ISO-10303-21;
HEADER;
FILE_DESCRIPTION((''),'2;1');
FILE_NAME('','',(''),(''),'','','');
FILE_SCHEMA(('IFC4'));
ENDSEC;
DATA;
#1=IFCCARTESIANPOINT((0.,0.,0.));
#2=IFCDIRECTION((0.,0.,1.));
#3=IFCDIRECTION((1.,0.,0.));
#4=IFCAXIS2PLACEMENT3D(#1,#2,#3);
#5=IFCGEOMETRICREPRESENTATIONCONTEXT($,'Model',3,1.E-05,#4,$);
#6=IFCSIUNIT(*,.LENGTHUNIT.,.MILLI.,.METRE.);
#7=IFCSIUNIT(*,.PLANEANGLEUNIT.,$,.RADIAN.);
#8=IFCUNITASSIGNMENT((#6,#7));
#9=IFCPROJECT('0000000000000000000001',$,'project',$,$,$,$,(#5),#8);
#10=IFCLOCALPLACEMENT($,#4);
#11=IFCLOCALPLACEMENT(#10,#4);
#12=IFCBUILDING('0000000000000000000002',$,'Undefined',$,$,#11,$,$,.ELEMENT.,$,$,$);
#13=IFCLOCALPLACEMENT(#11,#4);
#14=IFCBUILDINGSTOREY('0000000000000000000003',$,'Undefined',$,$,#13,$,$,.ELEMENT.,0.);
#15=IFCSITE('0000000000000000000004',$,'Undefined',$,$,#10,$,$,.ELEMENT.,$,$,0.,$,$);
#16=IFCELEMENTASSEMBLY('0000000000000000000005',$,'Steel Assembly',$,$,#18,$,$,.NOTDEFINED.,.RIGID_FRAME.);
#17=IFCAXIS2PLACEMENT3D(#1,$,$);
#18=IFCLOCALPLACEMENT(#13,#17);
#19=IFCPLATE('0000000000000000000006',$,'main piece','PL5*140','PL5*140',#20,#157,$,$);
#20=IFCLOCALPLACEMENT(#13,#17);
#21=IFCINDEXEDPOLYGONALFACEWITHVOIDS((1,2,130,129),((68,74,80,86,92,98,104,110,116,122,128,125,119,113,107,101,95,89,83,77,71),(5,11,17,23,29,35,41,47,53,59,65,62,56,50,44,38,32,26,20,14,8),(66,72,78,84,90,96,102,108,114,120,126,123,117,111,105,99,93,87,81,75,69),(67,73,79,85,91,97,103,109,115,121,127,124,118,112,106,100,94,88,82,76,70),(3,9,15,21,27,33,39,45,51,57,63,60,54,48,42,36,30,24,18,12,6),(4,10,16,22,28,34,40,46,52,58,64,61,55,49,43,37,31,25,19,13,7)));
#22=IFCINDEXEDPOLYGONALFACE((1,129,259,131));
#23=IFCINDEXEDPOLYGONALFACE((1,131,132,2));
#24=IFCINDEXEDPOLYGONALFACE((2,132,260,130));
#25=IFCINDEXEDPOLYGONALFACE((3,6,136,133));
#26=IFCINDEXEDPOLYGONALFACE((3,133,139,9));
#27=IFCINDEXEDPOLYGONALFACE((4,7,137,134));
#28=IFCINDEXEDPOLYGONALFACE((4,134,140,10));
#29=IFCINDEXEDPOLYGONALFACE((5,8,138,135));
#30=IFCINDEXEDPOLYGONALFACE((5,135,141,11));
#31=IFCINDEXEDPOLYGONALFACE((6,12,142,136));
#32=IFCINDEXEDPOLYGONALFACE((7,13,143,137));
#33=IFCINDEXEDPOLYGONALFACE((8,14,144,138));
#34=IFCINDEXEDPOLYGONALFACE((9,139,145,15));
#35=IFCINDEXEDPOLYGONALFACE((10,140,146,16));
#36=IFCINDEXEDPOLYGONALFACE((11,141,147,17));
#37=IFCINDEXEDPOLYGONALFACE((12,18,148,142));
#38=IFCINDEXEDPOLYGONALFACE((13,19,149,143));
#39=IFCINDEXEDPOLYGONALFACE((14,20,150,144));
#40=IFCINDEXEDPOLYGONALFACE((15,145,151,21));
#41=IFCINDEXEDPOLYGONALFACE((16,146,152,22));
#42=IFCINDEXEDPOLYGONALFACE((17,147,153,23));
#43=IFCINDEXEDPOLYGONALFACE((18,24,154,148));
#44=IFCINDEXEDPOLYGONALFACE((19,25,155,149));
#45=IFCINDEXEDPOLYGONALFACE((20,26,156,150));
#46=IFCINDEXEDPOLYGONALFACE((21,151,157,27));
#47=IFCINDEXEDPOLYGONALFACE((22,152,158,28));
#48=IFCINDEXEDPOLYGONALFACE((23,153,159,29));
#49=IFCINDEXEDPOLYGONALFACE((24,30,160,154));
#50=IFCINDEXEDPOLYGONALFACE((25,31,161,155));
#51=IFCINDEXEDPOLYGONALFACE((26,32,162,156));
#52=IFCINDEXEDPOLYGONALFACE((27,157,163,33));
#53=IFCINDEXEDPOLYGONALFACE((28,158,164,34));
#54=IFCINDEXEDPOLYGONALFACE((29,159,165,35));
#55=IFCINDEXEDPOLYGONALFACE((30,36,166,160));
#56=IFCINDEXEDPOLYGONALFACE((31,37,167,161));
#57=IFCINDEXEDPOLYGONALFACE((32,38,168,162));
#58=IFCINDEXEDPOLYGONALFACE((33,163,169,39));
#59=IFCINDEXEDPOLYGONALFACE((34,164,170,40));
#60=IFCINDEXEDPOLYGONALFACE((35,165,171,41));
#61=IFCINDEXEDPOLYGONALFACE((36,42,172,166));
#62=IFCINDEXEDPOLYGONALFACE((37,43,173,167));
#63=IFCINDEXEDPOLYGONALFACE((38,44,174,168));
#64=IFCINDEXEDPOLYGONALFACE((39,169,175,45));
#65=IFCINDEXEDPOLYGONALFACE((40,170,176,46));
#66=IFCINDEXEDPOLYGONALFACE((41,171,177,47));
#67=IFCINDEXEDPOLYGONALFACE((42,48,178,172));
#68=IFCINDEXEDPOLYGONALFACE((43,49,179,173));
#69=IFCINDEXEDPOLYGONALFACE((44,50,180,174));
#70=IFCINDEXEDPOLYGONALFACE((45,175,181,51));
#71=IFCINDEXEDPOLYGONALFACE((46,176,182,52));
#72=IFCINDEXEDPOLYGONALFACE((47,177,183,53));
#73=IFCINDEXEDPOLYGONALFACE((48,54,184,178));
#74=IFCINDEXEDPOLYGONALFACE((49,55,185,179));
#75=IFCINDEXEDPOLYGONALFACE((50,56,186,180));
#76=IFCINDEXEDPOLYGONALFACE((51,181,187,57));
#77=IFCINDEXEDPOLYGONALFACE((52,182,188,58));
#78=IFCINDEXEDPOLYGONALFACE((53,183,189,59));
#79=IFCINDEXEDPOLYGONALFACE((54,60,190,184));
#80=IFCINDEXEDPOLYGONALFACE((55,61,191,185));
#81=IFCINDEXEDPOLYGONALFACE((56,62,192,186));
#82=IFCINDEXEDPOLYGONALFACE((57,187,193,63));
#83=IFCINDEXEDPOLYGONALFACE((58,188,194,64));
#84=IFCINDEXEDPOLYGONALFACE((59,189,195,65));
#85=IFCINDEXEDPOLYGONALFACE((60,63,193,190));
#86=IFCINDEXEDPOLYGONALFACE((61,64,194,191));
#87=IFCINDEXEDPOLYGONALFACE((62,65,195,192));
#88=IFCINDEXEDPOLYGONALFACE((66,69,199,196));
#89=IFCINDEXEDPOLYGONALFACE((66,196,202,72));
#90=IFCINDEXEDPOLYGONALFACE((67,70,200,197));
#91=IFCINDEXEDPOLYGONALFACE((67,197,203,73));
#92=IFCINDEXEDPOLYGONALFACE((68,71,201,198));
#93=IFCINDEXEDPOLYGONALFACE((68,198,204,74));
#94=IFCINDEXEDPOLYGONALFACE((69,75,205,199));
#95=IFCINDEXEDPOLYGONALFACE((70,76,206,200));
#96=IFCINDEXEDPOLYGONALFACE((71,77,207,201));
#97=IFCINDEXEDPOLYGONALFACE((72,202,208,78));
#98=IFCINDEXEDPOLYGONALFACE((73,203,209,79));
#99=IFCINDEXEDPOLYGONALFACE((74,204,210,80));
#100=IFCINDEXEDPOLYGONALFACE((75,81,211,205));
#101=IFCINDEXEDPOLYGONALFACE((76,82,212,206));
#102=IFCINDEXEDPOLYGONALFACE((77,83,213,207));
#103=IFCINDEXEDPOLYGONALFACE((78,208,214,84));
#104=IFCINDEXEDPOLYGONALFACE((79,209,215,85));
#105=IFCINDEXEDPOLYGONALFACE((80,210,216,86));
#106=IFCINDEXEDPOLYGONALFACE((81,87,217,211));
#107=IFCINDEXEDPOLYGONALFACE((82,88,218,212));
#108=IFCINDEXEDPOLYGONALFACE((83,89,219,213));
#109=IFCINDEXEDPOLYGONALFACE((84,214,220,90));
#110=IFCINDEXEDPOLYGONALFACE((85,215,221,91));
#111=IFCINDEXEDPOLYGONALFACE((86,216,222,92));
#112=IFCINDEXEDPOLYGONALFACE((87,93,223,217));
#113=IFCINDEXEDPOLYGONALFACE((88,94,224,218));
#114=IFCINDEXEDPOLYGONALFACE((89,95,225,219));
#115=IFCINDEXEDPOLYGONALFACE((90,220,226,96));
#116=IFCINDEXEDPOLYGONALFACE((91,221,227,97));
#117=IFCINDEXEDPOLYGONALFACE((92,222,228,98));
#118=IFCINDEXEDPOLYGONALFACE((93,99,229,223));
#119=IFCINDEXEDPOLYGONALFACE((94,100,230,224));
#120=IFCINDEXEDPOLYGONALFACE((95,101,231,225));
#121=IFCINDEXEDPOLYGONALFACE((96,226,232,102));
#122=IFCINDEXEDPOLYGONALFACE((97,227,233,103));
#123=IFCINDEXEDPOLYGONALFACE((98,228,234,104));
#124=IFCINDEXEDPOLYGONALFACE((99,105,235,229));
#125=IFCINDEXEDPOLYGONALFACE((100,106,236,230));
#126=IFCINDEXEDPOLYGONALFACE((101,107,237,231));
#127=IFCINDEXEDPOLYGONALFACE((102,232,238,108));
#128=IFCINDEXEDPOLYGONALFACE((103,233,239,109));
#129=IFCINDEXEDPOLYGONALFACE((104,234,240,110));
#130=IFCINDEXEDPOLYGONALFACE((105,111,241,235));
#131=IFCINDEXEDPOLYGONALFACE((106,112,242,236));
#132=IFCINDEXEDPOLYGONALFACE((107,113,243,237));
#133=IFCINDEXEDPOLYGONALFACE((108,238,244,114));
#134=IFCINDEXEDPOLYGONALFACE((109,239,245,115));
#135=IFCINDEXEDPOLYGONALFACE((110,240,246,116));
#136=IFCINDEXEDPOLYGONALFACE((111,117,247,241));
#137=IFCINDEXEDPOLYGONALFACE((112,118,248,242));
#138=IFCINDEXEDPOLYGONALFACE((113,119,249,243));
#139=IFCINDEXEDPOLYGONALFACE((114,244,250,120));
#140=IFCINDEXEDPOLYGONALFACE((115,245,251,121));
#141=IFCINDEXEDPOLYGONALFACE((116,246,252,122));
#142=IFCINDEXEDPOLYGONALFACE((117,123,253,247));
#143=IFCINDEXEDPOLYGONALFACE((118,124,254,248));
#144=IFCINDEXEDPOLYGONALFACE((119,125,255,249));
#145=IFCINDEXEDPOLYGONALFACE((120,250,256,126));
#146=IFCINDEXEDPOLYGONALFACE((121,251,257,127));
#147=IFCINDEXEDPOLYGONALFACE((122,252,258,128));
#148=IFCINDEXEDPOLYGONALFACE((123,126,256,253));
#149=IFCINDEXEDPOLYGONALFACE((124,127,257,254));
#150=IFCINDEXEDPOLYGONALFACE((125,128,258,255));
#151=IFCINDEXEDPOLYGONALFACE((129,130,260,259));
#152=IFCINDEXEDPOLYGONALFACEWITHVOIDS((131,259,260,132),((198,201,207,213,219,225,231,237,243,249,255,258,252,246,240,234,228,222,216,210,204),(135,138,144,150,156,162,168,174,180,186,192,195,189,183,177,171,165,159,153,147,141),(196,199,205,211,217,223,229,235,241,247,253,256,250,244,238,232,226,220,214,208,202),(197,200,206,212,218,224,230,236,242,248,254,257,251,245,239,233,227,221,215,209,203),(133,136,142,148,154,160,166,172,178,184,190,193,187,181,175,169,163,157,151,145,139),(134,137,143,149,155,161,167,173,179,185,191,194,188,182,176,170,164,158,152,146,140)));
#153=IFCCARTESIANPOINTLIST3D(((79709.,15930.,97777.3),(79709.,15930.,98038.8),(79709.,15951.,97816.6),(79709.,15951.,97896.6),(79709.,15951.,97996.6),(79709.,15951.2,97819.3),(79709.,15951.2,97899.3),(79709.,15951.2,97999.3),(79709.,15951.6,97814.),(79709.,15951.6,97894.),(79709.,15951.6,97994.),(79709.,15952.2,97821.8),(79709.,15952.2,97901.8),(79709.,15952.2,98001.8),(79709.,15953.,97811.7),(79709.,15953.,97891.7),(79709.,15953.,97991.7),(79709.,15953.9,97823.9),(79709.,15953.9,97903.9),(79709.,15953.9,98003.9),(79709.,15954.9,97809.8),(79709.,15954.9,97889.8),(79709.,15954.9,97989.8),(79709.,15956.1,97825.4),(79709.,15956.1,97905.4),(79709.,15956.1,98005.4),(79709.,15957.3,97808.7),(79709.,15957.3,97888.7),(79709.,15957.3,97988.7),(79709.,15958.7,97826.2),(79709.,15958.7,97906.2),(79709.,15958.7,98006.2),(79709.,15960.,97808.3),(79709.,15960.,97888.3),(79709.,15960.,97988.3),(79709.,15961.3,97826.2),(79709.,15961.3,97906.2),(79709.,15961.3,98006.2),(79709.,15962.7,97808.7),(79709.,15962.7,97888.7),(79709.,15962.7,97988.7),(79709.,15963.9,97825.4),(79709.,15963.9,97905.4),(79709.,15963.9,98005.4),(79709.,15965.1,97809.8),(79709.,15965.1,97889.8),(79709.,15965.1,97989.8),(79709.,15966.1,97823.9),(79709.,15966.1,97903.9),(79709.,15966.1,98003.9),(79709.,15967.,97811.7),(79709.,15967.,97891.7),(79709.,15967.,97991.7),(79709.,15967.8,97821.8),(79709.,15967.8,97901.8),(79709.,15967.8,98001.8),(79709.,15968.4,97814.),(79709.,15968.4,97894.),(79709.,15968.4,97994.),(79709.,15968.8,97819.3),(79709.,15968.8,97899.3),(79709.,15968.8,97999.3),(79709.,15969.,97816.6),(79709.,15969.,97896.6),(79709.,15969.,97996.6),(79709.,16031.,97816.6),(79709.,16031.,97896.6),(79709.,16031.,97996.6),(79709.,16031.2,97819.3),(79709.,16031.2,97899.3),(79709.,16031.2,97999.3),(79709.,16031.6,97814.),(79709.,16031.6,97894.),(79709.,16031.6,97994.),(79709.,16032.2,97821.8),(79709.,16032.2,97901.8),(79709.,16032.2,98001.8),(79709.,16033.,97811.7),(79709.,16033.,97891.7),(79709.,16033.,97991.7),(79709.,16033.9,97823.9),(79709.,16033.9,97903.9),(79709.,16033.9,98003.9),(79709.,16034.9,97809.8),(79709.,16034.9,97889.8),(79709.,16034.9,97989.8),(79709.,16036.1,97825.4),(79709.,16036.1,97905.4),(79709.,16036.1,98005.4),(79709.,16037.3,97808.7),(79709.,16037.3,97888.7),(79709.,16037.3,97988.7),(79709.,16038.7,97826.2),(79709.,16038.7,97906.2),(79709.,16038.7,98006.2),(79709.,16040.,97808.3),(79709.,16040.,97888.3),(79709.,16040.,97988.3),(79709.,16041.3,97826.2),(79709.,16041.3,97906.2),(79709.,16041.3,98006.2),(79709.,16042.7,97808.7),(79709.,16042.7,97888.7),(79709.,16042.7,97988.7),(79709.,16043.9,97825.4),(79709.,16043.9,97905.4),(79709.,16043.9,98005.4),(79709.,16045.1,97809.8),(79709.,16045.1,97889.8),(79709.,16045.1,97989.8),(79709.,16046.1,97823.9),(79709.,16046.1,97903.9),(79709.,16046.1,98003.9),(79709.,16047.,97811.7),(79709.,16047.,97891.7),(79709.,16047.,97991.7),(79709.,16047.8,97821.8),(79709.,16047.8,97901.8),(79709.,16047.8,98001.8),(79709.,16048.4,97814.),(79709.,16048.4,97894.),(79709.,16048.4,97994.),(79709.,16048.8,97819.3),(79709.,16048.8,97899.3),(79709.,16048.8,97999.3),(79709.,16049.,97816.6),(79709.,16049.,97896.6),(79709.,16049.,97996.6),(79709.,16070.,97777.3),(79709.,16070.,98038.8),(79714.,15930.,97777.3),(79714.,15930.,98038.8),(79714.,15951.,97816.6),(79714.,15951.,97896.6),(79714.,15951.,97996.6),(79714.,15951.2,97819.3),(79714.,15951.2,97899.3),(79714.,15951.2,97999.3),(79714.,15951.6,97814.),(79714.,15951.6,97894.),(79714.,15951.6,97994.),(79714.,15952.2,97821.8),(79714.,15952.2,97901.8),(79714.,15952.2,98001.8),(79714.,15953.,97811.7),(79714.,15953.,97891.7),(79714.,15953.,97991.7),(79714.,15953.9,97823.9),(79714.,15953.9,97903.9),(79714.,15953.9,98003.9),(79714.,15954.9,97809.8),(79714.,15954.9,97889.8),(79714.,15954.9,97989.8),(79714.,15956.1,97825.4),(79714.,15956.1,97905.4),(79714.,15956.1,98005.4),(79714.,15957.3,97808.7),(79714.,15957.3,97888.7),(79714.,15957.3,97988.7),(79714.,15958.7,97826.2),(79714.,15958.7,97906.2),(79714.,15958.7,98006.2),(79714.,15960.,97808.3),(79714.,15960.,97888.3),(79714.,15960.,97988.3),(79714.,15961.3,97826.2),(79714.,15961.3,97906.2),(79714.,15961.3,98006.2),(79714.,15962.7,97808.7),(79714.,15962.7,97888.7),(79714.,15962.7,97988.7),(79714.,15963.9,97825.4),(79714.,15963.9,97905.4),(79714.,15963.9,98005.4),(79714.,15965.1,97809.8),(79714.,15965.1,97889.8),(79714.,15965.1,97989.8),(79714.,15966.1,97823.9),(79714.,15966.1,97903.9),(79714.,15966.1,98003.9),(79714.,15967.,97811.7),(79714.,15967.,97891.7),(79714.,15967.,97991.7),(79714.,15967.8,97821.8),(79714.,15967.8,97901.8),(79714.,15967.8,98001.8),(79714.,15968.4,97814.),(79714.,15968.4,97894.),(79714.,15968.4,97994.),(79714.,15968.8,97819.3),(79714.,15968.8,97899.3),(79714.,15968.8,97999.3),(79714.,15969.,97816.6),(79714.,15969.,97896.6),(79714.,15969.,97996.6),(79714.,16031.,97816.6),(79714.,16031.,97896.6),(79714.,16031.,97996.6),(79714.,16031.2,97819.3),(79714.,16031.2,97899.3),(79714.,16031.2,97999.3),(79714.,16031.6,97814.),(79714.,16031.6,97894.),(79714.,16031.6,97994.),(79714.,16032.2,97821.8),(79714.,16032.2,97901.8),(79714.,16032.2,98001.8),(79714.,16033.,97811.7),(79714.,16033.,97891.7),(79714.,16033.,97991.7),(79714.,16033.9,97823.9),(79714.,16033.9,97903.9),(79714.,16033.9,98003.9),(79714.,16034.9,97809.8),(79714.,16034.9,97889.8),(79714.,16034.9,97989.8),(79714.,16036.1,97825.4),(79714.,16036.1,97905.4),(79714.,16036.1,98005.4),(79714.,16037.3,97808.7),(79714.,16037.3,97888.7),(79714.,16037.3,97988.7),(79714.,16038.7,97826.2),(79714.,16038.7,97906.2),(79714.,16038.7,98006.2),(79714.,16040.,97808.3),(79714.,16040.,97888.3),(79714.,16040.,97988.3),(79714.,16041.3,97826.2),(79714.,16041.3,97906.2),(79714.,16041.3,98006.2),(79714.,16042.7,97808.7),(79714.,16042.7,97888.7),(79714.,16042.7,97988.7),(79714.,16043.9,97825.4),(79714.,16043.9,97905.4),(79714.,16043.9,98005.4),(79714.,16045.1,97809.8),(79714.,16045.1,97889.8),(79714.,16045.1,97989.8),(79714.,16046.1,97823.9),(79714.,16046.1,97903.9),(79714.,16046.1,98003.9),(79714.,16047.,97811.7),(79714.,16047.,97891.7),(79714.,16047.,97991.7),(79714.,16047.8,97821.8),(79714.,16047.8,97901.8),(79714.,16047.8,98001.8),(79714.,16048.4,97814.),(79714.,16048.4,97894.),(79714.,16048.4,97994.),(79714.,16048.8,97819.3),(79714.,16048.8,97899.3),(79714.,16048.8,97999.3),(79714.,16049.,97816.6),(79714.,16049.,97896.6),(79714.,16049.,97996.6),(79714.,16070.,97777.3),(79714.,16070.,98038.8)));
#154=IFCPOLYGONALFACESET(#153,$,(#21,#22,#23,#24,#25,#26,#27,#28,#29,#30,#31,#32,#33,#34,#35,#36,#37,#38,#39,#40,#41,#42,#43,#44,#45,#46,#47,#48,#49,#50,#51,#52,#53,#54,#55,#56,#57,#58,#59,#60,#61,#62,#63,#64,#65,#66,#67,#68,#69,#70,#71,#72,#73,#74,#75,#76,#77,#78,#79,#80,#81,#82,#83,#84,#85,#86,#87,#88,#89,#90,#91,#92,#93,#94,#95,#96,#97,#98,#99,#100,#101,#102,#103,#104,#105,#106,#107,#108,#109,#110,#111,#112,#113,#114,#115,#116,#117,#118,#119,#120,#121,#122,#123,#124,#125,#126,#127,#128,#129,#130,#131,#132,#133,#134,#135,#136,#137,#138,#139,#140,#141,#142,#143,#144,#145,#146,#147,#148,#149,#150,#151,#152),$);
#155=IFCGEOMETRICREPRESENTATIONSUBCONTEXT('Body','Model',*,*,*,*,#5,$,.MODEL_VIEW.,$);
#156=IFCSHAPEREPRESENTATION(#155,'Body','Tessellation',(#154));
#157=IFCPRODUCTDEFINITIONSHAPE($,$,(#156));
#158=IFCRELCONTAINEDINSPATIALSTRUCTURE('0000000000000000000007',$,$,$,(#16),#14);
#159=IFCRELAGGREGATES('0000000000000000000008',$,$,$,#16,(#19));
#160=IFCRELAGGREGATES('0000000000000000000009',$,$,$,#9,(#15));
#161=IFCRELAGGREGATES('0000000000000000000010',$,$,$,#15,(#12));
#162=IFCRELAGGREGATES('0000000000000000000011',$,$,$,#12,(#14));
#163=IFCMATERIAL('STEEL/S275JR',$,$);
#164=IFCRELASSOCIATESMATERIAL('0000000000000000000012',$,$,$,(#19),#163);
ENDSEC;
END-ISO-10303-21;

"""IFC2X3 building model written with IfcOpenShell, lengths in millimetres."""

from ifc_helpers import new_model, si_unit, frame, origin_with_axes, origin_2d_with_axis, place, context, subcontext, project, spatial, polyline, circle, outline, extrude, source, transform, mapped, material, element, aggregate, save


model = new_model("IFC2X3")

# Units and contexts
model_context = context("Model", 3, precision=1e-05, world=origin_with_axes())
body_context = subcontext(model_context, "Body", "Model", "MODEL_VIEW")
ifc_project = project(units=[si_unit("LENGTHUNIT", "METRE", prefix="MILLI"), si_unit("PLANEANGLEUNIT", "RADIAN")], contexts=[model_context])

# Site, building, storey
site_placement = place(None, origin_with_axes())
site = spatial("IfcSite", under=ifc_project, at=site_placement, Name="Undefined", CompositionType="ELEMENT", RefElevation=0.0)
building_placement = place(site_placement, origin_with_axes())
building = spatial("IfcBuilding", under=site, at=building_placement, Name="Undefined", CompositionType="ELEMENT")
storey_placement = place(building_placement, origin_with_axes())
storey = spatial("IfcBuildingStorey", under=building, at=storey_placement, Name="Undefined", CompositionType="ELEMENT", Elevation=0.0)

# Element assembly, plate, opening
assembly_1_placement = place(storey_placement, origin_with_axes())
assembly_1 = element("IfcElementAssembly", 1, at=assembly_1_placement, inside=storey, Name="Steel Assembly", AssemblyPlace="NOTDEFINED", PredefinedType="RIGID_FRAME")
ifc_material_1 = material(Name="STEEL/S275JR")
plate_1_placement = place(assembly_1_placement, frame((79711.5, 15930.0, 98038.8), z_axis=(-1.0, 0.0, 0.0), x_axis=(0.0, 1.0, 0.0)))
plate_1 = element("IfcPlate", 2, at=plate_1_placement, material=ifc_material_1, Name="main piece", Description="PL5*140", ObjectType="PL5*140", context=body_context, shape_type="SweptSolid", body=[
    extrude(outline(polyline([(0.0, 0.0), (140.0, 0.0), (140.0, 261.5), (0.0, 261.5), (0.0, 0.0)])), frame((0.0, 0.0, -2.5), z_axis=(0.0, 0.0, 1.0), x_axis=(1.0, 0.0, 0.0)), (0.0, 0.0, 1.0), 5.0),
])
shared_shape_1 = source(origin_with_axes(), body_context, "Body", "SweptSolid", [
    extrude(circle(Radius=9.0, at=origin_2d_with_axis()), frame((0.0, -5.1, 0.0), z_axis=(0.0, 1.0, 0.0), x_axis=(1.0, 0.0, 0.0)), (0.0, 0.0, 1.0), 10.3),
])
opening_1_placement = place(assembly_1_placement, frame((79714.0, 16000.0, 97997.3), z_axis=(0.0, -1.0, 0.0), x_axis=(0.0, 0.0, -1.0)))
element("IfcOpeningElement", 3, at=opening_1_placement, cuts=plate_1, ObjectType="Opening", context=body_context, shape_type="MappedRepresentation", body=[
    mapped(shared_shape_1, transform((0.0, 0.0, -40.0))),
    mapped(shared_shape_1, transform((100.0, 0.0, -40.0))),
    mapped(shared_shape_1, transform((180.0, 0.0, -40.0))),
    mapped(shared_shape_1, transform((0.0, 0.0, 40.0))),
    mapped(shared_shape_1, transform((100.0, 0.0, 40.0))),
    mapped(shared_shape_1, transform((180.0, 0.0, 40.0))),
])
aggregate(assembly_1, [plate_1])

save(model, "model.ifc")
